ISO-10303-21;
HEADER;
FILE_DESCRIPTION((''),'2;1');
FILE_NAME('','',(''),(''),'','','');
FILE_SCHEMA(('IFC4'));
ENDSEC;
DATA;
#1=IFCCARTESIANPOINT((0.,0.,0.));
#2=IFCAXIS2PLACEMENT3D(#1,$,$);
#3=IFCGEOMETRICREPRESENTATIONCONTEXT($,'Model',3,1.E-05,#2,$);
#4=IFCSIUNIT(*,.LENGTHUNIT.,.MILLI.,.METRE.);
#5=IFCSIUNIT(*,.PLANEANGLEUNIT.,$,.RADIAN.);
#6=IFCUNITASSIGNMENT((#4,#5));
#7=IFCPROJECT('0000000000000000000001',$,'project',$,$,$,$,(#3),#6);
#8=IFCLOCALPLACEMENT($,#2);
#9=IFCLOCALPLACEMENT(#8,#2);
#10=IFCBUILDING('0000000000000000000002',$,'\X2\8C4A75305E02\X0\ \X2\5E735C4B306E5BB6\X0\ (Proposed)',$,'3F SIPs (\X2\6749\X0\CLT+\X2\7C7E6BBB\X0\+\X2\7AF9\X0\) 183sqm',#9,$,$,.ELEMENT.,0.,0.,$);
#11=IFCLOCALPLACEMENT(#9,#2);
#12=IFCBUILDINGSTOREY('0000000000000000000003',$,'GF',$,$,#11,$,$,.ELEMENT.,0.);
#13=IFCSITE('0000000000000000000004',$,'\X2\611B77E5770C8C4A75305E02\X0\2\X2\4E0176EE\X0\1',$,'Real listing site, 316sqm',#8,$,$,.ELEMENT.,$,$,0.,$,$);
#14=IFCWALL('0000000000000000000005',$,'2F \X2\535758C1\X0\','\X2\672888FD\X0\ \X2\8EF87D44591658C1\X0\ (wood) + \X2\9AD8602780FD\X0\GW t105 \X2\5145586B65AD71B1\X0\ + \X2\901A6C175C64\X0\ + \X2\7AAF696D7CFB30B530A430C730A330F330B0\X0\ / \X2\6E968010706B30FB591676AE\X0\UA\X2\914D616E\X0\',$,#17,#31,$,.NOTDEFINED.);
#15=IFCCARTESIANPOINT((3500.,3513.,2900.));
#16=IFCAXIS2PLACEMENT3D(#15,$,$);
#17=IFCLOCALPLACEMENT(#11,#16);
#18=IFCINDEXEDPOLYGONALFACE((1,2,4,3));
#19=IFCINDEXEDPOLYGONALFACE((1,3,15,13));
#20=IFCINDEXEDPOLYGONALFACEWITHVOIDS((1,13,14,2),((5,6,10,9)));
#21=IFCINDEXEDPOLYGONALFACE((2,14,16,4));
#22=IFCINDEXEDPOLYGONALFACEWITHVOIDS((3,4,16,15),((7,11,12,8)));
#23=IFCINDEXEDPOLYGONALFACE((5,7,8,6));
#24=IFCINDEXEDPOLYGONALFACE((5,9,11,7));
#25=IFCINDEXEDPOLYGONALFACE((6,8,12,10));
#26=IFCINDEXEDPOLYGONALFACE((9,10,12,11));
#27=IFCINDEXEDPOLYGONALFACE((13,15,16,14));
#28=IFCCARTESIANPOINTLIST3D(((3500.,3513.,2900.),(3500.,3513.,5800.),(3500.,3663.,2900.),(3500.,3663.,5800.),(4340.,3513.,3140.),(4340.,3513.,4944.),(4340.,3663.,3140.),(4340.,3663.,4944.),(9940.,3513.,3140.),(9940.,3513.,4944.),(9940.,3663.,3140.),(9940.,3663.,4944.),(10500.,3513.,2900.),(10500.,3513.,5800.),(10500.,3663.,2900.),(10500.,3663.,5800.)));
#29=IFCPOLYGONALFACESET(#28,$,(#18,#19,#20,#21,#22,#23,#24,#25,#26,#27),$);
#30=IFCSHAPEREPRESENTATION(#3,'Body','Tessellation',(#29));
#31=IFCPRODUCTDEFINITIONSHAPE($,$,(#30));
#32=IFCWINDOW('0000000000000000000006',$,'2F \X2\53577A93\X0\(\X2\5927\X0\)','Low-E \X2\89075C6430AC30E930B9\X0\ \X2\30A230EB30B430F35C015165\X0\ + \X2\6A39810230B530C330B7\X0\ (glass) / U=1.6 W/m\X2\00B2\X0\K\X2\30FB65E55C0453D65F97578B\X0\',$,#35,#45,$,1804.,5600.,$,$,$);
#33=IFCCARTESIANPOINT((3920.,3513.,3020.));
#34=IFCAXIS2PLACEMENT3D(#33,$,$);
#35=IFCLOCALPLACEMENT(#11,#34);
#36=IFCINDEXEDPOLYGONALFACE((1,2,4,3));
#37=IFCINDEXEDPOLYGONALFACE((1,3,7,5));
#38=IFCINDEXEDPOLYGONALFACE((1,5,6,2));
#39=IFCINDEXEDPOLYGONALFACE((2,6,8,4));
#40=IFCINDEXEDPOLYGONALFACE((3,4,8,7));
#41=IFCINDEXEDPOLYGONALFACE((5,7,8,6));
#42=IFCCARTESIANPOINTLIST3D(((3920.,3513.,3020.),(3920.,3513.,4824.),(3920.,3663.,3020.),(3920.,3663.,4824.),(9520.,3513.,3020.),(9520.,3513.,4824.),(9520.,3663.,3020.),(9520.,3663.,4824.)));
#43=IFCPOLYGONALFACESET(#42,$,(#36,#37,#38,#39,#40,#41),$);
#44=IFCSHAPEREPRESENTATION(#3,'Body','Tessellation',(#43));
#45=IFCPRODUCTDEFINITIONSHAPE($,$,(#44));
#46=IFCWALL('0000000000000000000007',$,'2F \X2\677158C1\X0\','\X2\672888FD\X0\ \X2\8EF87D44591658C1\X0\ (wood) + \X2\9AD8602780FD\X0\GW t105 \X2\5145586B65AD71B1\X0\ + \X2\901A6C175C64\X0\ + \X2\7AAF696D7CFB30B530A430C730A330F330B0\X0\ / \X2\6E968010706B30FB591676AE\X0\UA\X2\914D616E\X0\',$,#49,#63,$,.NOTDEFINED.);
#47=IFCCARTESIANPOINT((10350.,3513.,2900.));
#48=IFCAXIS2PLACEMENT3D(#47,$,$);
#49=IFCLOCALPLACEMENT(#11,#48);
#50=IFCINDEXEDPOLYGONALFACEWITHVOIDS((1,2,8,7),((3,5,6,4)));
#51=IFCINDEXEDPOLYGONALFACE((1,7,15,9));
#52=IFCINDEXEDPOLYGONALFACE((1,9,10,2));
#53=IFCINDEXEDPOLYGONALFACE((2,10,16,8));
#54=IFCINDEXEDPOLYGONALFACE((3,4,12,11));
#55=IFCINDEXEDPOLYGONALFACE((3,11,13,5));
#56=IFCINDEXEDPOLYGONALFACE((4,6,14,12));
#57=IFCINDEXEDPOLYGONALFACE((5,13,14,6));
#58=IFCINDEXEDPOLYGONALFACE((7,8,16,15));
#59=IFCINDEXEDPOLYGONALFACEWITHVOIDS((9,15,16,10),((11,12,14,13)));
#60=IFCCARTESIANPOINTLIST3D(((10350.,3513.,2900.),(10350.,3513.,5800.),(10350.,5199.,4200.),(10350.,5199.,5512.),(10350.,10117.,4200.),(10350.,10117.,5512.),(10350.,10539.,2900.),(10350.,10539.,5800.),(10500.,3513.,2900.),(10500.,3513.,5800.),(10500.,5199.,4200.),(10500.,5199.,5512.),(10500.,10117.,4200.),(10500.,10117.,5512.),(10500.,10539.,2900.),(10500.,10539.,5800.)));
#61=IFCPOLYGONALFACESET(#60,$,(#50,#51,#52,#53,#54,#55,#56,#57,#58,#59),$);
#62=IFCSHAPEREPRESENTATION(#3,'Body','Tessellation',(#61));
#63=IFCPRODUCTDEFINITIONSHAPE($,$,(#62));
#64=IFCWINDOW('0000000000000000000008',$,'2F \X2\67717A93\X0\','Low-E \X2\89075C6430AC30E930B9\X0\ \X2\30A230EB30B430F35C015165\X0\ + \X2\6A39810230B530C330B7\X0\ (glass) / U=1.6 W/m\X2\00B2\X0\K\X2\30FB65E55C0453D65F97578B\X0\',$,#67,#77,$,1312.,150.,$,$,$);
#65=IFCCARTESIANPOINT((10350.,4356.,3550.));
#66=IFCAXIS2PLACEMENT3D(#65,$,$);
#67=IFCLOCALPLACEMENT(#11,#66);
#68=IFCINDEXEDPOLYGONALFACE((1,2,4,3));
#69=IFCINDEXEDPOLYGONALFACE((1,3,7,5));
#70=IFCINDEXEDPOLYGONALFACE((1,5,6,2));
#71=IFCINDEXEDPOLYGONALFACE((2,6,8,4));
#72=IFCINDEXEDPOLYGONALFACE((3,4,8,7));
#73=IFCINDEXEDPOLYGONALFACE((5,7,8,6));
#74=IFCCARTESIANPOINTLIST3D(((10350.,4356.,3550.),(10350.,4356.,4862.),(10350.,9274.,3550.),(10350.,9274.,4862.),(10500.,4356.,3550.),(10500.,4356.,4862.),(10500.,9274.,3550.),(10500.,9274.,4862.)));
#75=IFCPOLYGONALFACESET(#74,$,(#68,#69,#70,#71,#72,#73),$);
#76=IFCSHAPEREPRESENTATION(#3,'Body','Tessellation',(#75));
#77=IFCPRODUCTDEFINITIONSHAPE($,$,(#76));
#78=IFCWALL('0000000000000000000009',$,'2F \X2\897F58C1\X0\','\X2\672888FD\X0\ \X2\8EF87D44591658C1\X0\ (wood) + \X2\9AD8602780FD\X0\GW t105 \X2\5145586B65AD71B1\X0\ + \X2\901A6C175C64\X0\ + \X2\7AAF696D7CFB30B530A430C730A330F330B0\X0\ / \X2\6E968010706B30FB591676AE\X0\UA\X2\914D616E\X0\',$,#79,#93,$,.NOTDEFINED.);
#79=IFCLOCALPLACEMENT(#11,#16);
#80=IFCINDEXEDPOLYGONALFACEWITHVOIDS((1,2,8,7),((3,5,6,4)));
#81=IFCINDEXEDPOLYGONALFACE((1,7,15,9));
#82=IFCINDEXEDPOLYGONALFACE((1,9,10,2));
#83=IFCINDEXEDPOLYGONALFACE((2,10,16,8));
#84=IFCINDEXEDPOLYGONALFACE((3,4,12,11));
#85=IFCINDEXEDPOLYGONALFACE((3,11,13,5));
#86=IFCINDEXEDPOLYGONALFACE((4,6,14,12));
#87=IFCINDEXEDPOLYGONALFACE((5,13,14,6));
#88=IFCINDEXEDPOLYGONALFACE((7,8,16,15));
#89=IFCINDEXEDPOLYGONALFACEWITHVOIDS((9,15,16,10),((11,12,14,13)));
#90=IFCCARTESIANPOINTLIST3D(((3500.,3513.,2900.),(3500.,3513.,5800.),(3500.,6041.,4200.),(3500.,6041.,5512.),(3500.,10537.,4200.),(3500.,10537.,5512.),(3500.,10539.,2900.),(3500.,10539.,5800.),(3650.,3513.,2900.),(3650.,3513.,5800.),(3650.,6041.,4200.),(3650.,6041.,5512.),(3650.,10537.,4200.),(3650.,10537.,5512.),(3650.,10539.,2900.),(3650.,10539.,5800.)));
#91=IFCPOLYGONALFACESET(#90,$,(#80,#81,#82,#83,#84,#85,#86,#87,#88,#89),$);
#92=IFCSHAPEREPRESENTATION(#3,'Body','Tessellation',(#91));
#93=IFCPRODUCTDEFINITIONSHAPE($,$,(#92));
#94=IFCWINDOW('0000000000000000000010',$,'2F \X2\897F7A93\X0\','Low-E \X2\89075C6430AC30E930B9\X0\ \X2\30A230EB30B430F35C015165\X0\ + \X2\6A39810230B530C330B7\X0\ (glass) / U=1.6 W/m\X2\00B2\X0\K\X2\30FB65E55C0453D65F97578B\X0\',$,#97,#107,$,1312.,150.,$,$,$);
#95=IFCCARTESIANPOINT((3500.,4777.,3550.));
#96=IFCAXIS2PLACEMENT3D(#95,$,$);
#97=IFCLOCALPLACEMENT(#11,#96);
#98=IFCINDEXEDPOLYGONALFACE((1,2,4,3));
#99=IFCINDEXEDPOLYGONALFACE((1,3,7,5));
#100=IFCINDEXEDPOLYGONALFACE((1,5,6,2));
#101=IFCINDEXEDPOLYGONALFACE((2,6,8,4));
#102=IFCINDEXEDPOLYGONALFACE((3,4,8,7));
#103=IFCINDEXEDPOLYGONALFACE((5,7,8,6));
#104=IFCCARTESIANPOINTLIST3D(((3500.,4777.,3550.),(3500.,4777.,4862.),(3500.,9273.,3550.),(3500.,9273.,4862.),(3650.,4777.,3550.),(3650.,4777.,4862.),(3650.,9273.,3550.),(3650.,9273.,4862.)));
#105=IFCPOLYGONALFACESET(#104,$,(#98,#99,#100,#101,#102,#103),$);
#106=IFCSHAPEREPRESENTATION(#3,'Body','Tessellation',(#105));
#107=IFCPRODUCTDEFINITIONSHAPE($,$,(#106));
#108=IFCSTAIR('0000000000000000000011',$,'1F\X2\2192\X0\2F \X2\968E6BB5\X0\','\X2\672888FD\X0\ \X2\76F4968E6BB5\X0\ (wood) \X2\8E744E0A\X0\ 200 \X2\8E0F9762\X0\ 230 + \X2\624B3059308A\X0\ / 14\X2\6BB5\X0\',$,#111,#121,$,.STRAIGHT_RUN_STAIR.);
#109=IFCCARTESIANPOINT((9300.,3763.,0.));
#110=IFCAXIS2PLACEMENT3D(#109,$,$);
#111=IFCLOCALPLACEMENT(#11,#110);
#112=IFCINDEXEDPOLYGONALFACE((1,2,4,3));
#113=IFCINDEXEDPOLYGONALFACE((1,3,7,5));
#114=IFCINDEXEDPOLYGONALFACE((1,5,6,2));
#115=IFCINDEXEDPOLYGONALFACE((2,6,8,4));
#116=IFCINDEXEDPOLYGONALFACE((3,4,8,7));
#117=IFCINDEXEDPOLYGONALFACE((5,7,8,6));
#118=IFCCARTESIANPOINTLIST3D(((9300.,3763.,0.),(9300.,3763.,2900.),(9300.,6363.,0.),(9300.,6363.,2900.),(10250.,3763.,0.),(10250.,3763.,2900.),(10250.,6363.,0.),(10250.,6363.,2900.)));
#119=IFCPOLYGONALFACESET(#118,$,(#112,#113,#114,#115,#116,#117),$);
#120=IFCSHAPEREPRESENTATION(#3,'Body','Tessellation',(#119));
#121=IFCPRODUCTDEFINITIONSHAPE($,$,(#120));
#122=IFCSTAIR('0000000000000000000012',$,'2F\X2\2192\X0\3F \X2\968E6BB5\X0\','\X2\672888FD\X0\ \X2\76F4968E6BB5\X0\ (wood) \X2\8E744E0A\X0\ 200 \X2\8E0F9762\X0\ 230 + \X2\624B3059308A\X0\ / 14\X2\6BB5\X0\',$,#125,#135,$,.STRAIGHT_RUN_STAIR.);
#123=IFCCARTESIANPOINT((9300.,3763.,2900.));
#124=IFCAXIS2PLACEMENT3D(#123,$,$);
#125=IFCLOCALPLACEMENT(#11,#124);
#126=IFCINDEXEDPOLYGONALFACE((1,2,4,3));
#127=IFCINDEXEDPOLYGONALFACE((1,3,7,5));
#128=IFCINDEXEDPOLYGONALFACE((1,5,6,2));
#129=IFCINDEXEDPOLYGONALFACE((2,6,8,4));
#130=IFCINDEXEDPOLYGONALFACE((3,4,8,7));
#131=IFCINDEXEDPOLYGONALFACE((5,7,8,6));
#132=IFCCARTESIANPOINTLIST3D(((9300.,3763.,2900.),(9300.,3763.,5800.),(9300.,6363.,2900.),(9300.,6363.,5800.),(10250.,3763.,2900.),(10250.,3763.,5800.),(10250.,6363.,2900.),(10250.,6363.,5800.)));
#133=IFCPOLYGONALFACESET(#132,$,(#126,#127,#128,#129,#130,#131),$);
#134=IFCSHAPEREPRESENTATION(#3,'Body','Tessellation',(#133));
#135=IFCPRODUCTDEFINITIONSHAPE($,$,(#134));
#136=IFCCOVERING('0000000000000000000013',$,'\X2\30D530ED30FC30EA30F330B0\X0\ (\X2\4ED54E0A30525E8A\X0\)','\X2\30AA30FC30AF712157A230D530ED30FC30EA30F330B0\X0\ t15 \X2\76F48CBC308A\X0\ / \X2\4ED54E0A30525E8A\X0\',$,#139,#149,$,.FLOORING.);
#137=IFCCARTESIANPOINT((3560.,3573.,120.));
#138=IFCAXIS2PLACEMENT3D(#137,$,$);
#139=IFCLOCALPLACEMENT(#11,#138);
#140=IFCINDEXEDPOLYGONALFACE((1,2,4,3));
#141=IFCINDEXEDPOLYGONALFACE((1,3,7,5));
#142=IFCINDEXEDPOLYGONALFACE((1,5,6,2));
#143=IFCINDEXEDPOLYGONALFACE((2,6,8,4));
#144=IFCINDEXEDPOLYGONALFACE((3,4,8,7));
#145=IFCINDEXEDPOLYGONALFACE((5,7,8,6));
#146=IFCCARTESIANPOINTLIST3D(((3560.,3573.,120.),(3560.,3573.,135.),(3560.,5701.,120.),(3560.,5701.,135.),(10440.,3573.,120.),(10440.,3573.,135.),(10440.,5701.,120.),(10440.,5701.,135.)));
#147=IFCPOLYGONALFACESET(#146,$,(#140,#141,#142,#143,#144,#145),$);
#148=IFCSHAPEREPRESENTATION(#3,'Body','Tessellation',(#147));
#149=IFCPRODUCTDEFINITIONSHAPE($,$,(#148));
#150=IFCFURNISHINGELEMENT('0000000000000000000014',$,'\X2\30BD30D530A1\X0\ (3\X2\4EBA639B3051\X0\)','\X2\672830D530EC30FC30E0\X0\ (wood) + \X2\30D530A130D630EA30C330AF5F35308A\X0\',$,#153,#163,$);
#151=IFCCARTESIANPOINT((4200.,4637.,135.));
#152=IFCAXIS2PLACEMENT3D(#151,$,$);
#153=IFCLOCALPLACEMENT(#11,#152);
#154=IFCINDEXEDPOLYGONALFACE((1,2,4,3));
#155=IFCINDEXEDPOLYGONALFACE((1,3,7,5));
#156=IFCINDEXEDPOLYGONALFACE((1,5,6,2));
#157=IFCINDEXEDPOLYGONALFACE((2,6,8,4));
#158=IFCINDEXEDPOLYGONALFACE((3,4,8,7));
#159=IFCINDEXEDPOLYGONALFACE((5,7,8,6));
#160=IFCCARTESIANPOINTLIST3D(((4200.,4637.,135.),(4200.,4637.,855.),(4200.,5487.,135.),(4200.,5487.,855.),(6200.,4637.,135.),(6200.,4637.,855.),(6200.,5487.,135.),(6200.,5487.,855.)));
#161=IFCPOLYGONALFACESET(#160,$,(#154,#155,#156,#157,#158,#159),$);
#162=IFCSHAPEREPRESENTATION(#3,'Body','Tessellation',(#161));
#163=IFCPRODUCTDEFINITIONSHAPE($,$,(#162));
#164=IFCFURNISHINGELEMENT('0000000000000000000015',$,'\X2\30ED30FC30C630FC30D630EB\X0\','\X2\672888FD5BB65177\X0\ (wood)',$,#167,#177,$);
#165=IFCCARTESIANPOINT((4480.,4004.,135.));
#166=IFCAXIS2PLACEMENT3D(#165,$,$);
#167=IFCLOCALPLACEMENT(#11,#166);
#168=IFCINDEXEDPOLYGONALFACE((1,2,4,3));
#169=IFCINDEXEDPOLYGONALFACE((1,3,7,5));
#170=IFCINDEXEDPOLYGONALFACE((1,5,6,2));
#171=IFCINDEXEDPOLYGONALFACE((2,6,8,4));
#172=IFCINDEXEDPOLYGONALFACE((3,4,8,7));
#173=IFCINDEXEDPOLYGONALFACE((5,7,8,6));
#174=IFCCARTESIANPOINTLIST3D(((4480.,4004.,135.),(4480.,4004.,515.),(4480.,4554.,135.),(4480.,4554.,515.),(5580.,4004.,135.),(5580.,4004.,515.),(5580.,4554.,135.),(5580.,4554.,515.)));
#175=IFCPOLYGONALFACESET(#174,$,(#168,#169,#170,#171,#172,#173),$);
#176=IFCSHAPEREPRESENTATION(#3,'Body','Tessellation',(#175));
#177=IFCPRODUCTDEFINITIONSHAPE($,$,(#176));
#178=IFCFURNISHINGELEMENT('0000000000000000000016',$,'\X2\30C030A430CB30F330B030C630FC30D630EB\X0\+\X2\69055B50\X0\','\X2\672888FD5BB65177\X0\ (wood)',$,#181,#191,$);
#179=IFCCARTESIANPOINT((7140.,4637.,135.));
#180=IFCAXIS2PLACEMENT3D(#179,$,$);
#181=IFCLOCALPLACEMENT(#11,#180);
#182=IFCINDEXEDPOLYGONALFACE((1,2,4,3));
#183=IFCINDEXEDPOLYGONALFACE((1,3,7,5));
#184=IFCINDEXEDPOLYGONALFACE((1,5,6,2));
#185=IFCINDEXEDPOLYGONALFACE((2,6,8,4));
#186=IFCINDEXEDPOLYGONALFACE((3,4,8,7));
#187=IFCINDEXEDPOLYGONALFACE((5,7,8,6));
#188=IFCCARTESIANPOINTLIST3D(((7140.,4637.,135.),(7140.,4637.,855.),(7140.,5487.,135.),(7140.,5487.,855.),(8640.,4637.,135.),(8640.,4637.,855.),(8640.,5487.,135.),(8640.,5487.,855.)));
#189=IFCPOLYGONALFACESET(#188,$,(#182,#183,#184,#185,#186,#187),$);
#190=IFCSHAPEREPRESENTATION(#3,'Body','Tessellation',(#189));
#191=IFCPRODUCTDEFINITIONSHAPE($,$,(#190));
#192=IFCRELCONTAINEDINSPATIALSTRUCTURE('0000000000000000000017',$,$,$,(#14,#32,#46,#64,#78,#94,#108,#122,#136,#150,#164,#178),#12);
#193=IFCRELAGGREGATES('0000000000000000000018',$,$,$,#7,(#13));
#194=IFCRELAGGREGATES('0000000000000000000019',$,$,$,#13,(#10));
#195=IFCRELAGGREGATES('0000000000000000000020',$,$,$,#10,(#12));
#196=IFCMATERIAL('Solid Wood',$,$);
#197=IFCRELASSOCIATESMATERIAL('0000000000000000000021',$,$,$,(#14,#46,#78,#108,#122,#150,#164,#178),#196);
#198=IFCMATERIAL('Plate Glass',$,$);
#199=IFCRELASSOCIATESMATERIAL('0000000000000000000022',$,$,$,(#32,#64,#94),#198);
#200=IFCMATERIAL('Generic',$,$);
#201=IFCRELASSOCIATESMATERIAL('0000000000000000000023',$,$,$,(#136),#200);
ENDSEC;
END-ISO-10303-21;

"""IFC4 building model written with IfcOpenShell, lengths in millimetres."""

from ifc_helpers import new_model, si_unit, frame, frame_2d, origin, place, context, project, spatial, rectangle, extrude, material, element, fill, save


model = new_model("IFC4")

# Units and contexts
model_context = context("Model", 3, precision=1e-05, world=origin())
ifc_project = project(units=[si_unit("LENGTHUNIT", "METRE", prefix="MILLI"), si_unit("PLANEANGLEUNIT", "RADIAN")], contexts=[model_context])

# Site, building, storey
site_placement = place(None, origin())
site = spatial("IfcSite", under=ifc_project, at=site_placement, Name="愛知県豊田市2丁目1", ObjectType="Real listing site, 316sqm", CompositionType="ELEMENT", RefElevation=0.0)
building_placement = place(site_placement, origin())
building = spatial("IfcBuilding", under=site, at=building_placement, Name="豊田市 平屋の家 (Proposed)", ObjectType="3F SIPs (杉CLT+籾殻+竹) 183sqm", CompositionType="ELEMENT", ElevationOfRefHeight=0.0, ElevationOfTerrain=0.0)
storey_placement = place(building_placement, origin())
storey = spatial("IfcBuildingStorey", under=building, at=storey_placement, Name="GF", CompositionType="ELEMENT", Elevation=0.0)

# Shared definitions
ifc_material_1 = material(Name="Solid Wood")

# Shared definitions
ifc_material_2 = material(Name="Plate Glass")

# Walls, openings, windows
wall_1_placement = place(storey_placement, frame((3500.0, 3513.0, 2900.0)))
wall_1 = element("IfcWall", 1, at=wall_1_placement, inside=storey, material=ifc_material_1, Name="2F 南壁", Description="木製 軸組外壁 (wood) + 高性能GW t105 充填断熱 + 通気層 + 窯業系サイディング / 準耐火・外皮UA配慮", PredefinedType="NOTDEFINED", context=model_context, shape_type="SweptSolid", body=[
    extrude(rectangle(XDim=7000.0, YDim=150.0, at=frame_2d((3500.0, 75.0))), frame((3500.0, 3513.0, 2900.0)), (0.0, 0.0, 1.0), 2900.0),
])
opening_1_placement = place(storey_placement, frame((3920.0, 3513.0, 3020.0)))
opening_1 = element("IfcOpeningElement", 2, at=opening_1_placement, cuts=wall_1, PredefinedType="NOTDEFINED", context=model_context, shape_type="SweptSolid", body=[
    extrude(rectangle(XDim=5600.0, YDim=150.0, at=frame_2d((2800.0, 75.0))), frame((3920.0, 3513.0, 3020.0)), (0.0, 0.0, 1.0), 1804.0),
])
window_1_placement = place(storey_placement, frame((3920.0, 3513.0, 3020.0)))
window_1 = element("IfcWindow", 3, at=window_1_placement, inside=storey, material=ifc_material_2, Name="2F 南窓(大)", Description="Low-E 複層ガラス アルゴン封入 + 樹脂サッシ (glass) / U=1.6 W/m²K・日射取得型", OverallHeight=1804.0, OverallWidth=5600.0, context=model_context, shape_type="SweptSolid", body=[
    extrude(rectangle(XDim=5600.0, YDim=150.0, at=frame_2d((2800.0, 75.0))), frame((3920.0, 3513.0, 3020.0)), (0.0, 0.0, 1.0), 1804.0),
])
fill(opening_1, window_1)
wall_2_placement = place(storey_placement, frame((10350.0, 3513.0, 2900.0)))
wall_2 = element("IfcWall", 4, at=wall_2_placement, inside=storey, material=ifc_material_1, Name="2F 東壁", Description="木製 軸組外壁 (wood) + 高性能GW t105 充填断熱 + 通気層 + 窯業系サイディング / 準耐火・外皮UA配慮", PredefinedType="NOTDEFINED", context=model_context, shape_type="SweptSolid", body=[
    extrude(rectangle(XDim=150.0, YDim=7026.0, at=frame_2d((75.0, 3513.0))), frame((10350.0, 3513.0, 2900.0)), (0.0, 0.0, 1.0), 2900.0),
])
opening_2_placement = place(storey_placement, frame((10350.0, 4356.0, 3550.0)))
opening_2 = element("IfcOpeningElement", 5, at=opening_2_placement, cuts=wall_2, PredefinedType="NOTDEFINED", context=model_context, shape_type="SweptSolid", body=[
    extrude(rectangle(XDim=150.0, YDim=4918.0, at=frame_2d((75.0, 2459.0))), frame((10350.0, 4356.0, 3550.0)), (0.0, 0.0, 1.0), 1312.0),
])
window_2_placement = place(storey_placement, frame((10350.0, 4356.0, 3550.0)))
window_2 = element("IfcWindow", 6, at=window_2_placement, inside=storey, material=ifc_material_2, Name="2F 東窓", Description="Low-E 複層ガラス アルゴン封入 + 樹脂サッシ (glass) / U=1.6 W/m²K・日射取得型", OverallHeight=1312.0, OverallWidth=150.0, context=model_context, shape_type="SweptSolid", body=[
    extrude(rectangle(XDim=150.0, YDim=4918.0, at=frame_2d((75.0, 2459.0))), frame((10350.0, 4356.0, 3550.0)), (0.0, 0.0, 1.0), 1312.0),
])
fill(opening_2, window_2)
wall_3_placement = place(storey_placement, frame((3500.0, 3513.0, 2900.0)))
wall_3 = element("IfcWall", 7, at=wall_3_placement, inside=storey, material=ifc_material_1, Name="2F 西壁", Description="木製 軸組外壁 (wood) + 高性能GW t105 充填断熱 + 通気層 + 窯業系サイディング / 準耐火・外皮UA配慮", PredefinedType="NOTDEFINED", context=model_context, shape_type="SweptSolid", body=[
    extrude(rectangle(XDim=150.0, YDim=7026.0, at=frame_2d((75.0, 3513.0))), frame((3500.0, 3513.0, 2900.0)), (0.0, 0.0, 1.0), 2900.0),
])
opening_3_placement = place(storey_placement, frame((3500.0, 4777.0, 3550.0)))
opening_3 = element("IfcOpeningElement", 8, at=opening_3_placement, cuts=wall_3, PredefinedType="NOTDEFINED", context=model_context, shape_type="SweptSolid", body=[
    extrude(rectangle(XDim=150.0, YDim=4496.0, at=frame_2d((75.0, 2248.0))), frame((3500.0, 4777.0, 3550.0)), (0.0, 0.0, 1.0), 1312.0),
])
window_3_placement = place(storey_placement, frame((3500.0, 4777.0, 3550.0)))
window_3 = element("IfcWindow", 9, at=window_3_placement, inside=storey, material=ifc_material_2, Name="2F 西窓", Description="Low-E 複層ガラス アルゴン封入 + 樹脂サッシ (glass) / U=1.6 W/m²K・日射取得型", OverallHeight=1312.0, OverallWidth=150.0, context=model_context, shape_type="SweptSolid", body=[
    extrude(rectangle(XDim=150.0, YDim=4496.0, at=frame_2d((75.0, 2248.0))), frame((3500.0, 4777.0, 3550.0)), (0.0, 0.0, 1.0), 1312.0),
])
fill(opening_3, window_3)

# Stairs
stair_1_placement = place(storey_placement, frame((9300.0, 3763.0, 0.0)))
element("IfcStair", 10, at=stair_1_placement, inside=storey, material=ifc_material_1, Name="1F→2F 階段", Description="木製 直階段 (wood) 蹴上 200 踏面 230 + 手すり / 14段", PredefinedType="STRAIGHT_RUN_STAIR", context=model_context, shape_type="SweptSolid", body=[
    extrude(rectangle(XDim=950.0, YDim=2600.0, at=frame_2d((475.0, 1300.0))), frame((9300.0, 3763.0, 0.0)), (0.0, 0.0, 1.0), 2900.0),
])
stair_2_placement = place(storey_placement, frame((9300.0, 3763.0, 2900.0)))
element("IfcStair", 11, at=stair_2_placement, inside=storey, material=ifc_material_1, Name="2F→3F 階段", Description="木製 直階段 (wood) 蹴上 200 踏面 230 + 手すり / 14段", PredefinedType="STRAIGHT_RUN_STAIR", context=model_context, shape_type="SweptSolid", body=[
    extrude(rectangle(XDim=950.0, YDim=2600.0, at=frame_2d((475.0, 1300.0))), frame((9300.0, 3763.0, 2900.0)), (0.0, 0.0, 1.0), 2900.0),
])

# Covering
ifc_material_3 = material(Name="Generic")
covering_placement = place(storey_placement, frame((3560.0, 3573.0, 120.0)))
element("IfcCovering", 12, at=covering_placement, inside=storey, material=ifc_material_3, Name="フローリング (仕上げ床)", Description="オーク無垢フローリング t15 直貼り / 仕上げ床", PredefinedType="FLOORING", context=model_context, shape_type="SweptSolid", body=[
    extrude(rectangle(XDim=6880.0, YDim=2128.0, at=frame_2d((3440.0, 1064.0))), frame((3560.0, 3573.0, 120.0)), (0.0, 0.0, 1.0), 15.0),
])

# Furnishing elements
furnishing_1_placement = place(storey_placement, frame((4200.0, 4637.0, 135.0)))
element("IfcFurnishingElement", 13, at=furnishing_1_placement, inside=storey, material=ifc_material_1, Name="ソファ (3人掛け)", Description="木フレーム (wood) + ファブリック張り", context=model_context, shape_type="SweptSolid", body=[
    extrude(rectangle(XDim=2000.0, YDim=850.0, at=frame_2d((1000.0, 425.0))), frame((4200.0, 4637.0, 135.0)), (0.0, 0.0, 1.0), 720.0),
])
furnishing_2_placement = place(storey_placement, frame((4480.0, 4004.0, 135.0)))
element("IfcFurnishingElement", 14, at=furnishing_2_placement, inside=storey, material=ifc_material_1, Name="ローテーブル", Description="木製家具 (wood)", context=model_context, shape_type="SweptSolid", body=[
    extrude(rectangle(XDim=1100.0, YDim=550.0, at=frame_2d((550.0, 275.0))), frame((4480.0, 4004.0, 135.0)), (0.0, 0.0, 1.0), 380.0),
])
furnishing_3_placement = place(storey_placement, frame((7140.0, 4637.0, 135.0)))
element("IfcFurnishingElement", 15, at=furnishing_3_placement, inside=storey, material=ifc_material_1, Name="ダイニングテーブル+椅子", Description="木製家具 (wood)", context=model_context, shape_type="SweptSolid", body=[
    extrude(rectangle(XDim=1500.0, YDim=850.0, at=frame_2d((750.0, 425.0))), frame((7140.0, 4637.0, 135.0)), (0.0, 0.0, 1.0), 720.0),
])

save(model, "model.ifc")
